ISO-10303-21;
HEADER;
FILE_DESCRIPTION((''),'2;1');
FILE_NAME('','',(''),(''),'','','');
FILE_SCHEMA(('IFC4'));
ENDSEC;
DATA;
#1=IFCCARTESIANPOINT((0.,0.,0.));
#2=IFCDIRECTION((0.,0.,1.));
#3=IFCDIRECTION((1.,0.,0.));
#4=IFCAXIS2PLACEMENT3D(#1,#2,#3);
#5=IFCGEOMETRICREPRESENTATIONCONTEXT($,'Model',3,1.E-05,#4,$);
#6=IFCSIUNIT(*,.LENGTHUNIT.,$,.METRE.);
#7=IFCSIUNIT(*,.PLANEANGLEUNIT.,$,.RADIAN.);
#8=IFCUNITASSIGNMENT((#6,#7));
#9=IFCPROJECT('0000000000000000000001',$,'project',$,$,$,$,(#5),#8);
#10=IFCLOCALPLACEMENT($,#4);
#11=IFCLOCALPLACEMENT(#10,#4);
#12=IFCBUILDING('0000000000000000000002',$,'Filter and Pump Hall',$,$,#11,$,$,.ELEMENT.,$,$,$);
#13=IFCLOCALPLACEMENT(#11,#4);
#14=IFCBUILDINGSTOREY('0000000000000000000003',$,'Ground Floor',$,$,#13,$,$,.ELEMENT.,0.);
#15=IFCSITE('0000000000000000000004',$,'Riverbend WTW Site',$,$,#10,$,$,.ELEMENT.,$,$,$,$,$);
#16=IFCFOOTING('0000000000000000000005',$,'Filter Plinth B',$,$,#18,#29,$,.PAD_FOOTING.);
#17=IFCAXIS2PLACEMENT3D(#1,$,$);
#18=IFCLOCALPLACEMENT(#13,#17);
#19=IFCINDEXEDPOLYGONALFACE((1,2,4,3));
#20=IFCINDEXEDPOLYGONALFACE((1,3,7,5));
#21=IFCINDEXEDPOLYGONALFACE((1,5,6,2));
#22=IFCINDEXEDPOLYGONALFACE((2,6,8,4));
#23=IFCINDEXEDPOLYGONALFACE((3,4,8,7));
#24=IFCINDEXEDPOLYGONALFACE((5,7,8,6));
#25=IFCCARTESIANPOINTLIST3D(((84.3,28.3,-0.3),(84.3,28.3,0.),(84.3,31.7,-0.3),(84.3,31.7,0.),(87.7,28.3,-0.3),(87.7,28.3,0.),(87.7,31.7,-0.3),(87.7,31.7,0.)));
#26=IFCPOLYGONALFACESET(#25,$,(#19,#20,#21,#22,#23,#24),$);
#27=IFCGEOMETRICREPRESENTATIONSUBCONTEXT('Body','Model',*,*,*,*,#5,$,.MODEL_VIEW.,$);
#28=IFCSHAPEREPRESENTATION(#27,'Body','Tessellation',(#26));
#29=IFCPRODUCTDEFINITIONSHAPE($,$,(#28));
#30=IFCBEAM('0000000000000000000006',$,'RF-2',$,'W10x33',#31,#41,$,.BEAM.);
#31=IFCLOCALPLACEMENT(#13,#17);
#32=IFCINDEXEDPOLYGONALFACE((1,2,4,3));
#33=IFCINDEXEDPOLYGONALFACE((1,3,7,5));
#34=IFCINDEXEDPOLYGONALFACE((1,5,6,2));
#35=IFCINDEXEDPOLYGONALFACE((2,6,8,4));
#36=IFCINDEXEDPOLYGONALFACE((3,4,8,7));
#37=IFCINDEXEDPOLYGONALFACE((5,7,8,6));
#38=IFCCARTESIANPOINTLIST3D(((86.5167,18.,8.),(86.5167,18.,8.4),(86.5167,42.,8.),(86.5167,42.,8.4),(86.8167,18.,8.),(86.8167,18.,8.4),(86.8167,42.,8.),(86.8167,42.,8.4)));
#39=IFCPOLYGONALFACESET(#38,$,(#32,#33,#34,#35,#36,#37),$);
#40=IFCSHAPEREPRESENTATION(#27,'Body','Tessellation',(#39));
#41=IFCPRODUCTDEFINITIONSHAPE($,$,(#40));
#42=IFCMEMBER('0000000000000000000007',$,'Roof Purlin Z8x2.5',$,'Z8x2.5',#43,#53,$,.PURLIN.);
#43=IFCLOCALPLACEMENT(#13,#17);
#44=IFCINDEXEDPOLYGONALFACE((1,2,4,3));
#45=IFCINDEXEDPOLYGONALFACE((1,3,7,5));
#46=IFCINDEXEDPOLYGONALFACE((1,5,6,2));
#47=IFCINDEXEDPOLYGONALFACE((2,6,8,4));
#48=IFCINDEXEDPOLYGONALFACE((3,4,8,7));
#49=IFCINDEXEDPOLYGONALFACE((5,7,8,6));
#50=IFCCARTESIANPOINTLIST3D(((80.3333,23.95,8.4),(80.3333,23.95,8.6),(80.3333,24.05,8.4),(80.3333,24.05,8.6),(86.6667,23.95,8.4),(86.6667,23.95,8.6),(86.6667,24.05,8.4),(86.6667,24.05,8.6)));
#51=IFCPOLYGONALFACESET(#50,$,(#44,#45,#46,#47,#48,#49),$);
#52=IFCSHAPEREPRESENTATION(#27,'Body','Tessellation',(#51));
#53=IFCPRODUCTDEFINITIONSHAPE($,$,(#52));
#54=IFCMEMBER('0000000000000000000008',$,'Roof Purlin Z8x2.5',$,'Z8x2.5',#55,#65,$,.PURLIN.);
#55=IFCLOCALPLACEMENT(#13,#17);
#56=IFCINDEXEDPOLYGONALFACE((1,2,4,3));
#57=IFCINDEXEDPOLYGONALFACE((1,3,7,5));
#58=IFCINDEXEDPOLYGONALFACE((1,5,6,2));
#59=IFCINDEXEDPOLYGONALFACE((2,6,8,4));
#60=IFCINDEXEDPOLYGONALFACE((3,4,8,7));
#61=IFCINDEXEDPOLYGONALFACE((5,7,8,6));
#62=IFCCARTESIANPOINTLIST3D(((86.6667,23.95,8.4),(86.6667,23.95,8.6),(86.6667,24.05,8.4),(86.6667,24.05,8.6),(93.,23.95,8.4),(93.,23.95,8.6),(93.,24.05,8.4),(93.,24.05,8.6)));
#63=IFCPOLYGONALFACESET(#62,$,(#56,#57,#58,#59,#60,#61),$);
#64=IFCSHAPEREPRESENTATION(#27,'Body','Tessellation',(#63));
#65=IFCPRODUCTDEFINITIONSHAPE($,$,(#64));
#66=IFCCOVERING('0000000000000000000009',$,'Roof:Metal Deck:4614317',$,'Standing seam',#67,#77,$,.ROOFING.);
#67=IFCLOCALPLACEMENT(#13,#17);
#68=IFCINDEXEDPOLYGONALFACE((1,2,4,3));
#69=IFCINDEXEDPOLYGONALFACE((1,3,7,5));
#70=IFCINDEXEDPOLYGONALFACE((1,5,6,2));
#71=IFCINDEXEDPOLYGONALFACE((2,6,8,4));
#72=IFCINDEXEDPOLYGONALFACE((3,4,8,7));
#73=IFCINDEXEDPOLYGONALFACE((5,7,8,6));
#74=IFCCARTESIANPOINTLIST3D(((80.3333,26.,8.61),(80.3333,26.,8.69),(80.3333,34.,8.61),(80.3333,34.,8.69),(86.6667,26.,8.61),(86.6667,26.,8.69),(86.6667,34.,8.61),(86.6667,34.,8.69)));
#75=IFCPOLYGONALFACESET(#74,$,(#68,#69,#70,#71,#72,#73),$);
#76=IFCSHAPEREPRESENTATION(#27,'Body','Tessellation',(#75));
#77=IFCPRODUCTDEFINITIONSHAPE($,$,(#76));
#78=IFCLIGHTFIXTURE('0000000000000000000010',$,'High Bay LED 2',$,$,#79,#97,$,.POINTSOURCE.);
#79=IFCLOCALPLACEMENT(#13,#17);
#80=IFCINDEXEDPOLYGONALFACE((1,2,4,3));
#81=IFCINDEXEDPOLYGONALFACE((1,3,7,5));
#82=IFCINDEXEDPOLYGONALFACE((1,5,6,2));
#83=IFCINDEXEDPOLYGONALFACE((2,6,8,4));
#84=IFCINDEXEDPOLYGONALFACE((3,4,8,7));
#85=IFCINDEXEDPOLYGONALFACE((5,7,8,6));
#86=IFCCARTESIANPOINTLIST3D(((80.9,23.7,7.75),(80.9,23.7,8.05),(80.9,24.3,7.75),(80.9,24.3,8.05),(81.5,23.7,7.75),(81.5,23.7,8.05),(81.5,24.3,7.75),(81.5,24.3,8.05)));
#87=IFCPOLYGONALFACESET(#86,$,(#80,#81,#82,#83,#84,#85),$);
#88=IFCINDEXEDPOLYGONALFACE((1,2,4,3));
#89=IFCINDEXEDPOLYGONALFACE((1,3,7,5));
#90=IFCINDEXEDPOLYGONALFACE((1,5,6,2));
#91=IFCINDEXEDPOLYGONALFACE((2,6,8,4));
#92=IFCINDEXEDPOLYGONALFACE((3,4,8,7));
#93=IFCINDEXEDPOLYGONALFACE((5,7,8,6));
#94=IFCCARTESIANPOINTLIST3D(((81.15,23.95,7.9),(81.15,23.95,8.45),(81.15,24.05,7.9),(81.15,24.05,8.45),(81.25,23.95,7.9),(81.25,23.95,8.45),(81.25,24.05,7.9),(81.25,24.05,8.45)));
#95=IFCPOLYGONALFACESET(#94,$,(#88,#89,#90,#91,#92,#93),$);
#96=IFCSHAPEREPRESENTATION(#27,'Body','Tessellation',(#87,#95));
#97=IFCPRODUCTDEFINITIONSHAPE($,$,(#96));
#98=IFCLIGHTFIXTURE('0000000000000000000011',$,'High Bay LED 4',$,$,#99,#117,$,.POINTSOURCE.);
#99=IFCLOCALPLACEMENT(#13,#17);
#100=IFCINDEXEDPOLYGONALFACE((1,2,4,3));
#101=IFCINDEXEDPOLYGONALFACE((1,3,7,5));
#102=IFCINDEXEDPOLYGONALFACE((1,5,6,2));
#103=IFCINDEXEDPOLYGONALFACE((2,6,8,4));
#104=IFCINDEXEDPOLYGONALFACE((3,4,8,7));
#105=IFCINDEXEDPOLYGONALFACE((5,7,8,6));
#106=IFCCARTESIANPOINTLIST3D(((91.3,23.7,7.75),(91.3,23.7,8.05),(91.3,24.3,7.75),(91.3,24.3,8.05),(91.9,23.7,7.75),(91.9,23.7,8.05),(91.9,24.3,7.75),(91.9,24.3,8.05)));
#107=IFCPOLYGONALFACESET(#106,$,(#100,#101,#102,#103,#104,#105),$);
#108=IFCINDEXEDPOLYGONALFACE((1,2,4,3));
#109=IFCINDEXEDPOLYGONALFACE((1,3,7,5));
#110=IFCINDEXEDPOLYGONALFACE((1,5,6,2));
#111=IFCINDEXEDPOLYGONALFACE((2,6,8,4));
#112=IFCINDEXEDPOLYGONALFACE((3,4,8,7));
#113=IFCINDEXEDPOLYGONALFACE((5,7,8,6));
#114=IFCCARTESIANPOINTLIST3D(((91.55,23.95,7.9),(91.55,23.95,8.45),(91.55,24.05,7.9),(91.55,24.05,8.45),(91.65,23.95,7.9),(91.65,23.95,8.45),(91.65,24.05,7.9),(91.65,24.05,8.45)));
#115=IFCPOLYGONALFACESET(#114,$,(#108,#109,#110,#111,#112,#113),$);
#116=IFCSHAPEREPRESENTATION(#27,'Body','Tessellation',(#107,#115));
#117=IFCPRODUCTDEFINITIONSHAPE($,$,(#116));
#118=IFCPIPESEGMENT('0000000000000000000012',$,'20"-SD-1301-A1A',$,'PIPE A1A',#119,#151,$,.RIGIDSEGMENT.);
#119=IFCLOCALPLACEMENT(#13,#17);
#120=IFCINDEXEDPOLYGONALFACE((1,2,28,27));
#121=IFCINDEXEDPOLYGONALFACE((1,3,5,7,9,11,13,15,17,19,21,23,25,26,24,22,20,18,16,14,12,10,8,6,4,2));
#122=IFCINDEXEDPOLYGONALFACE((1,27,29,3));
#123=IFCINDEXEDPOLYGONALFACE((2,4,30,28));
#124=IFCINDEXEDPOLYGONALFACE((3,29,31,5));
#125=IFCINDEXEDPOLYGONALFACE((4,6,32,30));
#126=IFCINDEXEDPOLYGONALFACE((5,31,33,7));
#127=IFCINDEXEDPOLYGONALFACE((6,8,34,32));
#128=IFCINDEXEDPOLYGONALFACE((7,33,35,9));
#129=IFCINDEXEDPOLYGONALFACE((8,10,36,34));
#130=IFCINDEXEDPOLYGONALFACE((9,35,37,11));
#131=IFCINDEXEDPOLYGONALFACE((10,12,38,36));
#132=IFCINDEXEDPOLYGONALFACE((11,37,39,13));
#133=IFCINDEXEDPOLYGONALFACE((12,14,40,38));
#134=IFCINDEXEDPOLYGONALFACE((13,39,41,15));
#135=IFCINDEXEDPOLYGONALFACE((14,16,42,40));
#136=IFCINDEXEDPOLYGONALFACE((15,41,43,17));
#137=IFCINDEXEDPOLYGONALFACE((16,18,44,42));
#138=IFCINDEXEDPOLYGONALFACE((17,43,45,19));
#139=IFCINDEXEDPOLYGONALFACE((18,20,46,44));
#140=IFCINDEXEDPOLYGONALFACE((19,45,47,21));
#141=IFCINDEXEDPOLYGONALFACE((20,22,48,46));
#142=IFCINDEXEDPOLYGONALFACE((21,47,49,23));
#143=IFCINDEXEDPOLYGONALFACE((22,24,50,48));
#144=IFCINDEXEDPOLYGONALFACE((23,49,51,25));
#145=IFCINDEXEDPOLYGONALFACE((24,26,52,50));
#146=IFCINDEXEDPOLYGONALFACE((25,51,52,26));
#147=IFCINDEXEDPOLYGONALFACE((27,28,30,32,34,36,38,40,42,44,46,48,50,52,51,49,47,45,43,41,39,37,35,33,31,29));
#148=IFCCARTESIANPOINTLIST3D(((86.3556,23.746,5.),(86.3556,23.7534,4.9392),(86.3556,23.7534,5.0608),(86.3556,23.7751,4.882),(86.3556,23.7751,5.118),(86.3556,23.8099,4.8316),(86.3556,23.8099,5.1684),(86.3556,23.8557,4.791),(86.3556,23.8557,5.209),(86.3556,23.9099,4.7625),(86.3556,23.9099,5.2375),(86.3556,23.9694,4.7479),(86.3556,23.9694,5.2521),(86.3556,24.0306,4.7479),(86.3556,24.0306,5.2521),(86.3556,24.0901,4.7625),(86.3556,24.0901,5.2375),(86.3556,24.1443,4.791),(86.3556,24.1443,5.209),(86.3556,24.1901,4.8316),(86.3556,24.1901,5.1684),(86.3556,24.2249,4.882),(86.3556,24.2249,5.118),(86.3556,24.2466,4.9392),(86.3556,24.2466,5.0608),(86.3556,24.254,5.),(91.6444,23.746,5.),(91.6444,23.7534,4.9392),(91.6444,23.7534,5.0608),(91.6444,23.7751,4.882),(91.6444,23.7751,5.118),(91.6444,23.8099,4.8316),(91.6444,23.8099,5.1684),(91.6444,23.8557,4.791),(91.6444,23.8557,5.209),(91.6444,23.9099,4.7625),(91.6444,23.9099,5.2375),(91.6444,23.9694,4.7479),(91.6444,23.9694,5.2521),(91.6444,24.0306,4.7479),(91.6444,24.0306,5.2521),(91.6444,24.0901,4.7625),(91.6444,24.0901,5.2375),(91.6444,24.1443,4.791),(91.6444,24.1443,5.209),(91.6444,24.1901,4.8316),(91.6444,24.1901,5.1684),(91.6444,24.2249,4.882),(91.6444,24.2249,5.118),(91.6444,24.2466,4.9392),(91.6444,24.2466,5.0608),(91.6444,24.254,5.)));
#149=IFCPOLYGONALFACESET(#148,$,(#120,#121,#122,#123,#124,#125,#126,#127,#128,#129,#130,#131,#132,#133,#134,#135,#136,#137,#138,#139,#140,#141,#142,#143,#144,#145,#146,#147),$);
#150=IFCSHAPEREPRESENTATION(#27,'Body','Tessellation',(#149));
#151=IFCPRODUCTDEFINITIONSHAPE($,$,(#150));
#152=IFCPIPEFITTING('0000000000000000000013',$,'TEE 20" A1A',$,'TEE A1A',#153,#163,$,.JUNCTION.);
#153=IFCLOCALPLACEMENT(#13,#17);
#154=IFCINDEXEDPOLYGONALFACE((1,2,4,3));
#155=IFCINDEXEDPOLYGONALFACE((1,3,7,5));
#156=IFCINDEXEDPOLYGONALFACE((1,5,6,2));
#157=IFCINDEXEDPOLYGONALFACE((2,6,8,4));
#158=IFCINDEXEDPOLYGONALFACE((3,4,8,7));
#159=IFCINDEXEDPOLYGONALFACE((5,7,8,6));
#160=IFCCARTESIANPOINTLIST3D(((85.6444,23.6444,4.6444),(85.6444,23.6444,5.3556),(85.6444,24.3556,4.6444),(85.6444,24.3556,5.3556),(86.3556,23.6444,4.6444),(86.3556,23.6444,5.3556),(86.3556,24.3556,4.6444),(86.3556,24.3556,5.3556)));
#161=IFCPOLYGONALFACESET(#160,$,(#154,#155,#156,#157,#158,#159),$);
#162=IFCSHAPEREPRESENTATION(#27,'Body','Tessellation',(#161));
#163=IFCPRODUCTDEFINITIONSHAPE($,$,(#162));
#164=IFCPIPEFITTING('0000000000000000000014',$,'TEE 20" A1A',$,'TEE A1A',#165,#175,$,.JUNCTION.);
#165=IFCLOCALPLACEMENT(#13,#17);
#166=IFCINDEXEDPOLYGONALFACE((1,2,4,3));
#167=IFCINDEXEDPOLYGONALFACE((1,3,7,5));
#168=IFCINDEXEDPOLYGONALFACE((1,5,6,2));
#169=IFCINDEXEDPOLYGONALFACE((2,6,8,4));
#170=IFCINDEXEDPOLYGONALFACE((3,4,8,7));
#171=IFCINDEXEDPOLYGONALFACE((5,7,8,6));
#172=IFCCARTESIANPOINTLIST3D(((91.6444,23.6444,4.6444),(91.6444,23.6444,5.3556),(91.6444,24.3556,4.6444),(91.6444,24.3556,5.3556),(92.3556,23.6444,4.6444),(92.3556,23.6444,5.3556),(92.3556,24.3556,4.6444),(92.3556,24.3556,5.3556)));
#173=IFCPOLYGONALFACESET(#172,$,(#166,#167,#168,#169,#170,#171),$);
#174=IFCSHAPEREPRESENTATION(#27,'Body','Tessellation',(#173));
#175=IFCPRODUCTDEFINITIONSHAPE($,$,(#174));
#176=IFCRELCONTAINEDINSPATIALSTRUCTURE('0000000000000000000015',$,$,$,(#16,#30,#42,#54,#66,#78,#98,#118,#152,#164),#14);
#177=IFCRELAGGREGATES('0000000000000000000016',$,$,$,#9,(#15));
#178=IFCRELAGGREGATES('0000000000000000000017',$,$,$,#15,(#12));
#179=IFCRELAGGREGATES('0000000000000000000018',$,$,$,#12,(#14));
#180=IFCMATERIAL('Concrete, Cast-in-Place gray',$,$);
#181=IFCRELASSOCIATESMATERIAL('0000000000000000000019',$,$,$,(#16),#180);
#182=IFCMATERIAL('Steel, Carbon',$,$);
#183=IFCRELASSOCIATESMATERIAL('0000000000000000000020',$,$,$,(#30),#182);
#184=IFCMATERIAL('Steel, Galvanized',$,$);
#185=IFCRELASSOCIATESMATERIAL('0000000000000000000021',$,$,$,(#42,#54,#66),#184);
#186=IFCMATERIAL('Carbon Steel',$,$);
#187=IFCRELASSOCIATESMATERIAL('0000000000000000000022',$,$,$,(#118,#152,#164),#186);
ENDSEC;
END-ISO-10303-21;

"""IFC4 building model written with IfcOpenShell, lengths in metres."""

from ifc_helpers import new_model, si_unit, frame, origin_with_axes, origin_2d, place, context, subcontext, project, spatial, rectangle, circle, extrude, material, element, save


model = new_model("IFC4")

# Units and contexts
model_context = context("Model", 3, precision=1e-05, world=origin_with_axes())
body_context = subcontext(model_context, "Body", "Model", "MODEL_VIEW")
ifc_project = project(units=[si_unit("LENGTHUNIT", "METRE"), si_unit("PLANEANGLEUNIT", "RADIAN")], contexts=[model_context])

# Site, building, storey
site_placement = place(None, origin_with_axes())
site = spatial("IfcSite", under=ifc_project, at=site_placement, Name="Riverbend WTW Site", CompositionType="ELEMENT")
building_placement = place(site_placement, origin_with_axes())
building = spatial("IfcBuilding", under=site, at=building_placement, Name="Filter and Pump Hall", CompositionType="ELEMENT")
storey_placement = place(building_placement, origin_with_axes())
storey = spatial("IfcBuildingStorey", under=building, at=storey_placement, Name="Ground Floor", CompositionType="ELEMENT", Elevation=0.0)

# Footing
ifc_material_1 = material(Name="Concrete, Cast-in-Place gray")
footing_placement = place(None, frame((86.0, 30.0, -0.15), z_axis=(0.0, 0.0, 1.0), x_axis=(1.0, 0.0, 0.0)))
element("IfcFooting", 1, at=footing_placement, inside=storey, material=ifc_material_1, Name="Filter Plinth B", PredefinedType="PAD_FOOTING", context=body_context, shape_type="SweptSolid", body=[
    extrude(rectangle(XDim=3.4, YDim=3.4, at=origin_2d()), frame((0.0, 0.0, -0.15), z_axis=(0.0, 0.0, 1.0), x_axis=(1.0, 0.0, 0.0)), (0.0, 0.0, 1.0), 0.3),
])

# Beam
ifc_material_2 = material(Name="Steel, Carbon")
beam_placement = place(None, frame((86.6667, 30.0, 8.2), z_axis=(0.0, 0.0, 1.0), x_axis=(1.0, 0.0, 0.0)))
element("IfcBeam", 2, at=beam_placement, inside=storey, material=ifc_material_2, Name="RF-2", ObjectType="W10x33", PredefinedType="BEAM", context=body_context, shape_type="SweptSolid", body=[
    extrude(rectangle(XDim=0.3, YDim=24.0, at=origin_2d()), frame((0.0, 0.0, -0.2), z_axis=(0.0, 0.0, 1.0), x_axis=(1.0, 0.0, 0.0)), (0.0, 0.0, 1.0), 0.4),
])

# Members
ifc_material_3 = material(Name="Steel, Galvanized")
member_1_placement = place(None, frame((83.5, 24.0, 8.5), z_axis=(0.0, 0.0, 1.0), x_axis=(1.0, 0.0, 0.0)))
element("IfcMember", 3, at=member_1_placement, inside=storey, material=ifc_material_3, Name="Roof Purlin Z8x2.5", ObjectType="Z8x2.5", PredefinedType="PURLIN", context=body_context, shape_type="SweptSolid", body=[
    extrude(rectangle(XDim=6.3333, YDim=0.1, at=origin_2d()), frame((0.0, 0.0, -0.1), z_axis=(0.0, 0.0, 1.0), x_axis=(1.0, 0.0, 0.0)), (0.0, 0.0, 1.0), 0.2),
])
member_2_placement = place(None, frame((89.8333, 24.0, 8.5), z_axis=(0.0, 0.0, 1.0), x_axis=(1.0, 0.0, 0.0)))
element("IfcMember", 4, at=member_2_placement, inside=storey, material=ifc_material_3, Name="Roof Purlin Z8x2.5", ObjectType="Z8x2.5", PredefinedType="PURLIN", context=body_context, shape_type="SweptSolid", body=[
    extrude(rectangle(XDim=6.3333, YDim=0.1, at=origin_2d()), frame((0.0, 0.0, -0.1), z_axis=(0.0, 0.0, 1.0), x_axis=(1.0, 0.0, 0.0)), (0.0, 0.0, 1.0), 0.2),
])

# Covering
covering_placement = place(None, frame((83.5, 30.0, 8.65), z_axis=(0.0, 0.0, 1.0), x_axis=(1.0, 0.0, 0.0)))
element("IfcCovering", 5, at=covering_placement, inside=storey, material=ifc_material_3, Name="Roof:Metal Deck:4614317", ObjectType="Standing seam", PredefinedType="ROOFING", context=body_context, shape_type="SweptSolid", body=[
    extrude(rectangle(XDim=6.3333, YDim=8.0, at=origin_2d()), frame((0.0, 0.0, -0.04), z_axis=(0.0, 0.0, 1.0), x_axis=(1.0, 0.0, 0.0)), (0.0, 0.0, 1.0), 0.08),
])

# Light fixtures
for number, where, z_axis, x_axis, name in (
    (6, (81.2, 24.0, 7.9), (0.0, 0.0, 1.0), (1.0, 0.0, 0.0), "High Bay LED 2"),
    (7, (91.6, 24.0, 7.9), (0.0, 0.0, 1.0), (1.0, 0.0, 0.0), "High Bay LED 4"),
):
    element("IfcLightFixture", number, at=place(None, frame(where, z_axis=z_axis, x_axis=x_axis)), inside=storey, Name=name, PredefinedType="POINTSOURCE", context=body_context, shape_type="SweptSolid", body=[
        extrude(rectangle(XDim=0.6, YDim=0.6, at=origin_2d()), frame((0.0, 0.0, -0.15), z_axis=(0.0, 0.0, 1.0), x_axis=(1.0, 0.0, 0.0)), (0.0, 0.0, 1.0), 0.3),
        extrude(rectangle(XDim=0.1, YDim=0.1, at=origin_2d()), origin_with_axes(), (0.0, 0.0, 1.0), 0.55),
    ])

# Pipe segment
ifc_material_4 = material(Name="Carbon Steel")
pipe_segment_1_placement = place(None, frame((86.3556, 24.0, 5.0), z_axis=(0.0, 0.0, 1.0), x_axis=(1.0, 0.0, 0.0)))
element("IfcPipeSegment", 8, at=pipe_segment_1_placement, inside=storey, material=ifc_material_4, Name="20\"-SD-1301-A1A", ObjectType="PIPE A1A", PredefinedType="RIGIDSEGMENT", context=body_context, shape_type="SweptSolid", body=[
    extrude(circle(Radius=0.254, at=origin_2d()), frame((0.0, 0.0, 0.0), z_axis=(1.0, 0.0, 0.0), x_axis=(0.0, 1.0, 0.0)), (0.0, 0.0, 1.0), 5.2888),
])

# Pipe fittings
for number, where, z_axis, x_axis, name in (
    (9, (86.0, 24.0, 5.0), (0.0, 0.0, 1.0), (1.0, 0.0, 0.0), "TEE 20\" A1A"),
    (10, (92.0, 24.0, 5.0), (0.0, 0.0, 1.0), (1.0, 0.0, 0.0), "TEE 20\" A1A"),
):
    element("IfcPipeFitting", number, at=place(None, frame(where, z_axis=z_axis, x_axis=x_axis)), inside=storey, material=ifc_material_4, Name=name, ObjectType="TEE A1A", PredefinedType="JUNCTION", context=body_context, shape_type="SweptSolid", body=[
        extrude(rectangle(XDim=0.7112, YDim=0.7112, at=origin_2d()), frame((0.0, 0.0, -0.3556), z_axis=(0.0, 0.0, 1.0), x_axis=(1.0, 0.0, 0.0)), (0.0, 0.0, 1.0), 0.7112),
    ])

save(model, "model.ifc")
